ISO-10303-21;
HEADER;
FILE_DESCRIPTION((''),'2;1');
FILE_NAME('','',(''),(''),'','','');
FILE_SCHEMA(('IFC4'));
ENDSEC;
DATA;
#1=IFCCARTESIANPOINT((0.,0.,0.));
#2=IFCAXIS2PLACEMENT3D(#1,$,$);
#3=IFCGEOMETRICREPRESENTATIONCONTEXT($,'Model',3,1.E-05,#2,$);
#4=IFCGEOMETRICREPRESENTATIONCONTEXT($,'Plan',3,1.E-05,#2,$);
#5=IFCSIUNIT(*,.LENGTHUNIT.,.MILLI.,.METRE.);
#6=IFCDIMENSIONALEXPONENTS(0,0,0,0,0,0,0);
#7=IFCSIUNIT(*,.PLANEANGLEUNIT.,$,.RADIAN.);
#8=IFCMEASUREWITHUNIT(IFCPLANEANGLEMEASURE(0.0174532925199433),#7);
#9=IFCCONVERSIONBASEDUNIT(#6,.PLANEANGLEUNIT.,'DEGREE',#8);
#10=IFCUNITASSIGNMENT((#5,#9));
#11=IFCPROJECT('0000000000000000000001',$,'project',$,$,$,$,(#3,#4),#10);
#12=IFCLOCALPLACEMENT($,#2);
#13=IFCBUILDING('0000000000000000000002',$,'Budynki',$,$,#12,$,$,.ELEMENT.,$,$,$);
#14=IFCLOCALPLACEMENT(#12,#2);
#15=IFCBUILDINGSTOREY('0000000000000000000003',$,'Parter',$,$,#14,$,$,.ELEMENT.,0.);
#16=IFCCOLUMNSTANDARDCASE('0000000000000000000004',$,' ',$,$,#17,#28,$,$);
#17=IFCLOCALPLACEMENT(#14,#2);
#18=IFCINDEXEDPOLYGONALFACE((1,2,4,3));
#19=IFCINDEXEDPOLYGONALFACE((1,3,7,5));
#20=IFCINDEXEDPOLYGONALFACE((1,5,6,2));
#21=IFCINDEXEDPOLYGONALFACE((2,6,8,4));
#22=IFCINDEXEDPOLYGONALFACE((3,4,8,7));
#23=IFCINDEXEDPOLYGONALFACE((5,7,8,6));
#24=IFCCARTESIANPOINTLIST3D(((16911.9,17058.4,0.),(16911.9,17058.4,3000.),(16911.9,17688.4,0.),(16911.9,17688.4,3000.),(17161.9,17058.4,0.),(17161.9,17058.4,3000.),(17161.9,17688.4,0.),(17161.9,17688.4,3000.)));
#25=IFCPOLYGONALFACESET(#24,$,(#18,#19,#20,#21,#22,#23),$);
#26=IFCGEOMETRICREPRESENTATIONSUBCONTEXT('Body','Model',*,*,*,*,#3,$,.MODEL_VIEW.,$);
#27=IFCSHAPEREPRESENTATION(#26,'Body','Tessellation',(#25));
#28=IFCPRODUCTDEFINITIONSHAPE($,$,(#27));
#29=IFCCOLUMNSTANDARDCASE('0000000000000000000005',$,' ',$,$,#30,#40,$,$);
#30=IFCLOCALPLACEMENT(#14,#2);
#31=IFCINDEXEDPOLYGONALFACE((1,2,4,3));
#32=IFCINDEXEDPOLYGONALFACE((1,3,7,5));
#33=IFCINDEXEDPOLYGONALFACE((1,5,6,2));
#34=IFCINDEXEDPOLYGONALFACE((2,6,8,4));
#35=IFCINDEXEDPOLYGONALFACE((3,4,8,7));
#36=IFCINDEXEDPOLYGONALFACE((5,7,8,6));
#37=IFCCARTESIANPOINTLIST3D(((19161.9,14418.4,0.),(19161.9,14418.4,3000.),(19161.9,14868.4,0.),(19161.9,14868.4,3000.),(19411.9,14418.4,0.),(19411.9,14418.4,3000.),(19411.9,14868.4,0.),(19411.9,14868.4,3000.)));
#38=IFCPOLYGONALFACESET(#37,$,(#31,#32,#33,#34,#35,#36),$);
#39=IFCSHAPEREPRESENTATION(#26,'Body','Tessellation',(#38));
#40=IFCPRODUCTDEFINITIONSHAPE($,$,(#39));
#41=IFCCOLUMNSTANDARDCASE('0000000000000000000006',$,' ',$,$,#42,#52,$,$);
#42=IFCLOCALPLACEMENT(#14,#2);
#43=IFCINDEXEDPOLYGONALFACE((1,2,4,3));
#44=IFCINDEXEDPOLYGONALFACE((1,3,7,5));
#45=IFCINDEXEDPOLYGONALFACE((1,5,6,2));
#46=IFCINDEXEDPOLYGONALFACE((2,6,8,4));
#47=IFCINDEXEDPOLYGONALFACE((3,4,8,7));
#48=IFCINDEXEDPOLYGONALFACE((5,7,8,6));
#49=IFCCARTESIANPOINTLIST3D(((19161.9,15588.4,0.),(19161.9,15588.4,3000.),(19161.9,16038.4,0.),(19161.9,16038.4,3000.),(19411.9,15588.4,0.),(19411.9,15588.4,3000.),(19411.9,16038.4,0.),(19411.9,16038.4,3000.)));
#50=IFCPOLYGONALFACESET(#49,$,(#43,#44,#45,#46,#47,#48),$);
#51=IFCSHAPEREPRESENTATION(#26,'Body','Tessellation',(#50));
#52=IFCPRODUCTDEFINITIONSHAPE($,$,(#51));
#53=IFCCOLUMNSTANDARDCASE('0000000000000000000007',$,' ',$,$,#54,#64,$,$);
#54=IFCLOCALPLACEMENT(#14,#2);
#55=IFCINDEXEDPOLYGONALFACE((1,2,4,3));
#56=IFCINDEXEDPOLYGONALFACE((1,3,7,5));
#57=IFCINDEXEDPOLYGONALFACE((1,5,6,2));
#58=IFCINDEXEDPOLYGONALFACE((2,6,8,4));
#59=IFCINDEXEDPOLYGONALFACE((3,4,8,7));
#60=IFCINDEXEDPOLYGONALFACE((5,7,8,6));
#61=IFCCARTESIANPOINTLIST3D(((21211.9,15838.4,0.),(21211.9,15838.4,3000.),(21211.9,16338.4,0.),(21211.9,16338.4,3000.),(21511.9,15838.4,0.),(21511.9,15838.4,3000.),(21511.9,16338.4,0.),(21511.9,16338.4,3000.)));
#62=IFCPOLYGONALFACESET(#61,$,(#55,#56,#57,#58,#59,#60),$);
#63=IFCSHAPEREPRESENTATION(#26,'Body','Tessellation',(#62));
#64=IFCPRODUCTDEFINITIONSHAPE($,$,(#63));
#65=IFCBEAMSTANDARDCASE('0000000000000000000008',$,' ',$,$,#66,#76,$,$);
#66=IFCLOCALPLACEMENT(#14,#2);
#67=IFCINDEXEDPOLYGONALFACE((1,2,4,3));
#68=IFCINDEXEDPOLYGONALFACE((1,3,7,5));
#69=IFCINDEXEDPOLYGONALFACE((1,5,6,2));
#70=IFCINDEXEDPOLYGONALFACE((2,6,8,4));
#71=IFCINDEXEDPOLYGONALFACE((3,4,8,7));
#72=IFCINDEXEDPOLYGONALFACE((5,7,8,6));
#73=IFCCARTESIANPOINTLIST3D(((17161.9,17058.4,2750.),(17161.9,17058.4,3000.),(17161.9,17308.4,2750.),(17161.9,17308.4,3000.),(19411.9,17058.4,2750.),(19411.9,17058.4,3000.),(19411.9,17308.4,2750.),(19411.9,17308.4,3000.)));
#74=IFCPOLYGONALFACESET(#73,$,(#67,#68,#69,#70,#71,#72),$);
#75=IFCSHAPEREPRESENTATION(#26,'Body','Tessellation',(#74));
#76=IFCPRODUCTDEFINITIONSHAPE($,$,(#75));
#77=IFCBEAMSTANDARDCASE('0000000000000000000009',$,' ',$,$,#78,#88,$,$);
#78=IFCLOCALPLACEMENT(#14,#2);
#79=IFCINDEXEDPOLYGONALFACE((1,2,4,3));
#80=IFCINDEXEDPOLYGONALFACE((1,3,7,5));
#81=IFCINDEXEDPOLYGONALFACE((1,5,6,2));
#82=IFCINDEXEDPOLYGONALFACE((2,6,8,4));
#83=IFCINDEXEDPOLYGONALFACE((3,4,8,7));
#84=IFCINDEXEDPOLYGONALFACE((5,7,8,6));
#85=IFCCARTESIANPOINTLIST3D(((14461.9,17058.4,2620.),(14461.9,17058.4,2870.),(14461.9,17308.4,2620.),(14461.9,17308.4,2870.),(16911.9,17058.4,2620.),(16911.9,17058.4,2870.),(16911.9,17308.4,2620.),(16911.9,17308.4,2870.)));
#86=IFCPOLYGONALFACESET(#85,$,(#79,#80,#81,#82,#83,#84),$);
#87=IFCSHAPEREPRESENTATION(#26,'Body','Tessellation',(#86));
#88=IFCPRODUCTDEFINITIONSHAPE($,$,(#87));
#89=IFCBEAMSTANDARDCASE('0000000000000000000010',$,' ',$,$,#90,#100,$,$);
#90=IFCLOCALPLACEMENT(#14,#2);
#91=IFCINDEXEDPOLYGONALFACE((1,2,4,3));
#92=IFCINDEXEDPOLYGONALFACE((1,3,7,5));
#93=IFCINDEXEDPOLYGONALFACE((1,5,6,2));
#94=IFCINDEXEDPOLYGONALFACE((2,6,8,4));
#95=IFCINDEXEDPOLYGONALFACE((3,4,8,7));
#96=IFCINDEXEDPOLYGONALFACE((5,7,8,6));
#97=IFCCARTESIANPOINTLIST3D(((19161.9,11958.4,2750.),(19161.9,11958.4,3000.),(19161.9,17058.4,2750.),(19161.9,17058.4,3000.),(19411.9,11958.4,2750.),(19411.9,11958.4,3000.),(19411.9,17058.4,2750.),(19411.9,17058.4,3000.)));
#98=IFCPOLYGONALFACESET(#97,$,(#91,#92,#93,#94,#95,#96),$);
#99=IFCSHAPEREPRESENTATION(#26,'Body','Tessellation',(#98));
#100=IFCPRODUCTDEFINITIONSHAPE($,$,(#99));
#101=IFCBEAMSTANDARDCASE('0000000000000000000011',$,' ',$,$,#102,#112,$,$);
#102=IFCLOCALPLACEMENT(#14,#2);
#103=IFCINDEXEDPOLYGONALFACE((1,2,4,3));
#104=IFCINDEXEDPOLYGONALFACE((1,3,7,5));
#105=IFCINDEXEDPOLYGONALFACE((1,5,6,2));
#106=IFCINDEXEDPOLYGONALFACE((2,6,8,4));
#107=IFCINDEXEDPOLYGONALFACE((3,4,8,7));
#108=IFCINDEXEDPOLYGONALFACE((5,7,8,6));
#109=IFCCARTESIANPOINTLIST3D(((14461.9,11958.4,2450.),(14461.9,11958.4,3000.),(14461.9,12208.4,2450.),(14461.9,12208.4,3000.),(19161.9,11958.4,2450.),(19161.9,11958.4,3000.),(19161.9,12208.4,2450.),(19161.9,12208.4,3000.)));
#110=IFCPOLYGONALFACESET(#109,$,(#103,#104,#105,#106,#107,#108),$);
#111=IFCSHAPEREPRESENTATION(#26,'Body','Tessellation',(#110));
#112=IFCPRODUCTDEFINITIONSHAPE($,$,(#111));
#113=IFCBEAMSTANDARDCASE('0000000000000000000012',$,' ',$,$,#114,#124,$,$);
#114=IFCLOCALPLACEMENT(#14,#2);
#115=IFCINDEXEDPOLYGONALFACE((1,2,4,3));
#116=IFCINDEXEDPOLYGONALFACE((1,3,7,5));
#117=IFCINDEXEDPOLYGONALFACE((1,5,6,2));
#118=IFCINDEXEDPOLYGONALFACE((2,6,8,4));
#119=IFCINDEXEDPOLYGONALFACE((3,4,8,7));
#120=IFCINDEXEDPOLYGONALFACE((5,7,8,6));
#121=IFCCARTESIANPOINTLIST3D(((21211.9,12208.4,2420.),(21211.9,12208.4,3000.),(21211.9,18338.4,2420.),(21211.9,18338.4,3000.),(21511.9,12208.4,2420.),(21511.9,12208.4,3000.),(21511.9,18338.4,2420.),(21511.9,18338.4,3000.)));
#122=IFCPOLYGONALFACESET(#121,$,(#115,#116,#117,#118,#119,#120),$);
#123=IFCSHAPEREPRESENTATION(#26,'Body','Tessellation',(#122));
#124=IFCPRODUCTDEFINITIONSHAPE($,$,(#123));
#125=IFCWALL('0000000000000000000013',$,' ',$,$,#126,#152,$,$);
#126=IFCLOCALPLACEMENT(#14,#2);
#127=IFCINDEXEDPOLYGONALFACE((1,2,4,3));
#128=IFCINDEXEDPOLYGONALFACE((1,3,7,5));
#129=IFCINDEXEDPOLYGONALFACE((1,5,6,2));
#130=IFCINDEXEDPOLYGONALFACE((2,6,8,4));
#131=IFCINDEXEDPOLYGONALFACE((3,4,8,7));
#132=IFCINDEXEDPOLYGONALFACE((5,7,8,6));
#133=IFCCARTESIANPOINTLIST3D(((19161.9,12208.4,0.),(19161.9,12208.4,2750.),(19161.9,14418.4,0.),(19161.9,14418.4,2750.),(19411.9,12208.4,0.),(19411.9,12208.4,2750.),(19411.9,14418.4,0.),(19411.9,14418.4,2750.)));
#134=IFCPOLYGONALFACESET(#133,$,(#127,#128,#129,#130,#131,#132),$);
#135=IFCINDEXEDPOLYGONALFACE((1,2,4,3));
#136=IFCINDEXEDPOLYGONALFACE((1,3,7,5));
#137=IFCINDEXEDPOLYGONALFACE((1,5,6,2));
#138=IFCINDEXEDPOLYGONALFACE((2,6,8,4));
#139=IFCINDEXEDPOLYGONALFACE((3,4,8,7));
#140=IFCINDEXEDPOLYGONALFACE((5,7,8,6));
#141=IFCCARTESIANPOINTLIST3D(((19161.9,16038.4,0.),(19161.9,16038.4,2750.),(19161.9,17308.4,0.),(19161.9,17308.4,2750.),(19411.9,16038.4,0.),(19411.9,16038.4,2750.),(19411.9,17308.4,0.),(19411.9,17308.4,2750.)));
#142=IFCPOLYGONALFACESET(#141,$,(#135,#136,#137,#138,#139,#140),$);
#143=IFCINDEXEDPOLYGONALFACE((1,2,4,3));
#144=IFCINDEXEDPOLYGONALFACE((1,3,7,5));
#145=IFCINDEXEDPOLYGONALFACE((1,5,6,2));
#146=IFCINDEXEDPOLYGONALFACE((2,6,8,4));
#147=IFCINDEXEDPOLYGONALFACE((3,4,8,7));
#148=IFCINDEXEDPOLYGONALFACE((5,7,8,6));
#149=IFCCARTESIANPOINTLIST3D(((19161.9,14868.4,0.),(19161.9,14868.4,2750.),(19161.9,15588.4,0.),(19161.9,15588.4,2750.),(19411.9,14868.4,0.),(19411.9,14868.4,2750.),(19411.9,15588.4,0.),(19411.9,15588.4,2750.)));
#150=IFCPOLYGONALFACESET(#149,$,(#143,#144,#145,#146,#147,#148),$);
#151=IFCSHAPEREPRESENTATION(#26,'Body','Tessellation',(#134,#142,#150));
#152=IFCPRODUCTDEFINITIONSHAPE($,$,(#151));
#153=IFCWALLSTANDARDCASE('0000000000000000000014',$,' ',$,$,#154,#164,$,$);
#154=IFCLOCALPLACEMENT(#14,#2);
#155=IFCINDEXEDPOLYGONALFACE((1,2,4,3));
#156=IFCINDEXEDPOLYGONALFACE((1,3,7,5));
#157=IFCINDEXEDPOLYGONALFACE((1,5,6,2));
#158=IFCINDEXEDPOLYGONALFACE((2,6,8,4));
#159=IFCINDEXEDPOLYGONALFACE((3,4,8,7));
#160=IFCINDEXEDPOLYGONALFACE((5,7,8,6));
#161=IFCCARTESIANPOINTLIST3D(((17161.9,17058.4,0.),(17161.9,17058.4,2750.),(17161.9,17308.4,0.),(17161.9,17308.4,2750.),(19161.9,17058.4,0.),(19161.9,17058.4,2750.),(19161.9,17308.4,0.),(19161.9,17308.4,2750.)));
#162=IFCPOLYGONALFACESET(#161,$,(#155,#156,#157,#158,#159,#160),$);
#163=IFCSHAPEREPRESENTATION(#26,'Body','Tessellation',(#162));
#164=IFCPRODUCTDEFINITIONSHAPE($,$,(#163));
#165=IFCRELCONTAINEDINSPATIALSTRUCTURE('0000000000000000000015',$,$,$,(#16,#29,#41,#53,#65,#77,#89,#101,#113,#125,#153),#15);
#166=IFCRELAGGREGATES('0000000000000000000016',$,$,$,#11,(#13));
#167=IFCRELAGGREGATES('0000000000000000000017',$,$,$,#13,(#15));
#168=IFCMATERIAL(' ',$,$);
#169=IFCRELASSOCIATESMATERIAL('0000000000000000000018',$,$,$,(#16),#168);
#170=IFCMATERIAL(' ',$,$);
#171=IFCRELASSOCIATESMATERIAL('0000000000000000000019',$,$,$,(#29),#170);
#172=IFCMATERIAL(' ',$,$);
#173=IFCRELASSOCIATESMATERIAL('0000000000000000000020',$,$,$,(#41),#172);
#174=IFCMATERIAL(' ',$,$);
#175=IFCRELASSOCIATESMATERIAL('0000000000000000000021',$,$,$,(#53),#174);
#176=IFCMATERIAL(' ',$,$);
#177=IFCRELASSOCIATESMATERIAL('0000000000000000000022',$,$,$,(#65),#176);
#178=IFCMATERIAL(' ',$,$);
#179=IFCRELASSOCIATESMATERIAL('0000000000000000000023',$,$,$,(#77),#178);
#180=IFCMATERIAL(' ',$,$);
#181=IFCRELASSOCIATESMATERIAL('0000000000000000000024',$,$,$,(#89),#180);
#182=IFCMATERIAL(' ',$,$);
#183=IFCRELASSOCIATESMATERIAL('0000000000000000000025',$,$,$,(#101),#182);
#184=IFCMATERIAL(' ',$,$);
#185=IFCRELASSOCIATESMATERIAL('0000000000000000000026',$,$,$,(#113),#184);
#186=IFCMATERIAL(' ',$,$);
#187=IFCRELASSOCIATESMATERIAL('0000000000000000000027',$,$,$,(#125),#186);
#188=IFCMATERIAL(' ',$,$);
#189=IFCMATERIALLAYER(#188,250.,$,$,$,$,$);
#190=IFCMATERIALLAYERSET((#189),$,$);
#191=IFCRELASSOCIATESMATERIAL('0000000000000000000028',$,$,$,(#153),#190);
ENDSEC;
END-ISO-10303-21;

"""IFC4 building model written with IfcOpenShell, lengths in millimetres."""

from ifc_helpers import new_model, entity, si_unit, converted_unit, frame, frame_2d, origin, origin_with_axes, place, context, subcontext, project, spatial, rectangle, extrude, material, layer, layer_set, layer_usage, material_profile, profile_set, profile_usage, element, save


model = new_model("IFC4")

# Units and contexts
model_context = context("Model", 3, precision=1e-05, world=origin())
plan_context = context("Plan", 3, precision=1e-05, world=origin())
body_context = subcontext(model_context, "Body", "Model", "MODEL_VIEW")
ifc_project = project(units=[si_unit("LENGTHUNIT", "METRE", prefix="MILLI"), converted_unit("PLANEANGLEUNIT", "DEGREE", entity("IfcPlaneAngleMeasure", 0.0174532925199433), si_unit("PLANEANGLEUNIT", "RADIAN"), dimensions=[0, 0, 0, 0, 0, 0, 0])], contexts=[model_context, plan_context])

# Building, storey
building_placement = place(None, origin())
building = spatial("IfcBuilding", under=ifc_project, at=building_placement, Name="Budynki", CompositionType="ELEMENT")
storey_placement = place(building_placement, origin())
storey = spatial("IfcBuildingStorey", under=building, at=storey_placement, Name="Parter", CompositionType="ELEMENT", Elevation=0.0)

# Columns
ifc_material_1 = material(Name=" ")
ifc_material_profile_1 = material_profile(ifc_material_1, rectangle(XDim=630.0, YDim=250.0, at=frame_2d((-125.0, 315.0), x_axis=(0.0, 1.0))))
ifc_profile_set_1 = profile_set([ifc_material_profile_1])
ifc_profile_usage_1 = profile_usage(ifc_profile_set_1)
column_1_placement = place(storey_placement, frame((16911.9, 17058.4, 0.0)))
element("IfcColumnStandardCase", 1, at=column_1_placement, inside=storey, material=ifc_profile_usage_1, Name=" ", context=body_context, shape_type="SweptSolid", body=[
    extrude(rectangle(XDim=630.0, YDim=250.0, at=frame_2d((-125.0, 315.0), x_axis=(0.0, 1.0))), frame((250.0, 0.0, 0.0), z_axis=(0.0, 0.0, 1.0), x_axis=(1.0, 0.0, 0.0)), (0.0, 0.0, 1.0), 3000.0),
])
ifc_material_2 = material(Name=" ")
ifc_material_profile_2 = material_profile(ifc_material_2, rectangle(XDim=450.0, YDim=250.0, at=frame_2d((125.0, -225.0), x_axis=(0.0, -1.0))))
ifc_profile_set_2 = profile_set([ifc_material_profile_2])
ifc_profile_usage_2 = profile_usage(ifc_profile_set_2)
column_2_placement = place(storey_placement, frame((19161.9, 14418.4, 0.0)))
element("IfcColumnStandardCase", 2, at=column_2_placement, inside=storey, material=ifc_profile_usage_2, Name=" ", context=body_context, shape_type="SweptSolid", body=[
    extrude(rectangle(XDim=450.0, YDim=250.0, at=frame_2d((125.0, -225.0), x_axis=(0.0, -1.0))), frame((0.0, 450.0, 0.0), z_axis=(0.0, 0.0, 1.0), x_axis=(1.0, 0.0, 0.0)), (0.0, 0.0, 1.0), 3000.0),
])
ifc_material_3 = material(Name=" ")
ifc_material_profile_3 = material_profile(ifc_material_3, rectangle(XDim=450.0, YDim=250.0, at=frame_2d((-125.0, 225.0), x_axis=(0.0, 1.0))))
ifc_profile_set_3 = profile_set([ifc_material_profile_3])
ifc_profile_usage_3 = profile_usage(ifc_profile_set_3)
column_3_placement = place(storey_placement, frame((19161.9, 15588.4, 0.0)))
element("IfcColumnStandardCase", 3, at=column_3_placement, inside=storey, material=ifc_profile_usage_3, Name=" ", context=body_context, shape_type="SweptSolid", body=[
    extrude(rectangle(XDim=450.0, YDim=250.0, at=frame_2d((-125.0, 225.0), x_axis=(0.0, 1.0))), frame((250.0, 0.0, 0.0), z_axis=(0.0, 0.0, 1.0), x_axis=(1.0, 0.0, 0.0)), (0.0, 0.0, 1.0), 3000.0),
])
ifc_material_4 = material(Name=" ")
ifc_material_profile_4 = material_profile(ifc_material_4, rectangle(XDim=500.0, YDim=300.0, at=frame_2d((150.0, -250.0), x_axis=(0.0, -1.0))))
ifc_profile_set_4 = profile_set([ifc_material_profile_4])
ifc_profile_usage_4 = profile_usage(ifc_profile_set_4)
column_4_placement = place(storey_placement, frame((21211.9, 15838.4, 0.0)))
element("IfcColumnStandardCase", 4, at=column_4_placement, inside=storey, material=ifc_profile_usage_4, Name=" ", context=body_context, shape_type="SweptSolid", body=[
    extrude(rectangle(XDim=500.0, YDim=300.0, at=frame_2d((150.0, -250.0), x_axis=(0.0, -1.0))), frame((0.0, 500.0, 0.0), z_axis=(0.0, 0.0, 1.0), x_axis=(1.0, 0.0, 0.0)), (0.0, 0.0, 1.0), 3000.0),
])

# Beams
ifc_material_5 = material(Name=" ")
ifc_material_profile_5 = material_profile(ifc_material_5, rectangle(XDim=250.0, YDim=250.0, at=frame_2d((125.0, -125.0), x_axis=(0.0, 1.0))))
ifc_profile_set_5 = profile_set([ifc_material_profile_5])
ifc_profile_usage_5 = profile_usage(ifc_profile_set_5)
beam_1_placement = place(storey_placement, frame((17161.9, 17058.4, 2750.0), z_axis=(0.0, 0.0, 1.0), x_axis=(1.0, 0.0, 0.0)))
element("IfcBeamStandardCase", 5, at=beam_1_placement, inside=storey, material=ifc_profile_usage_5, Name=" ", context=body_context, shape_type="SweptSolid", body=[
    extrude(rectangle(XDim=250.0, YDim=250.0, at=frame_2d((125.0, -125.0), x_axis=(0.0, 1.0))), frame((0.0, 0.0, 0.0), z_axis=(1.0, 0.0, 0.0), x_axis=(0.0, 0.0, 1.0)), (0.0, 0.0, 1.0), 2250.0),
])
ifc_material_6 = material(Name=" ")
ifc_material_profile_6 = material_profile(ifc_material_6, rectangle(XDim=250.0, YDim=250.0, at=frame_2d((125.0, -125.0), x_axis=(0.0, 1.0))))
ifc_profile_set_6 = profile_set([ifc_material_profile_6])
ifc_profile_usage_6 = profile_usage(ifc_profile_set_6)
beam_2_placement = place(storey_placement, frame((16911.9, 17308.4, 2620.0), z_axis=(0.0, 0.0, 1.0), x_axis=(-1.0, 0.0, 0.0)))
element("IfcBeamStandardCase", 6, at=beam_2_placement, inside=storey, material=ifc_profile_usage_6, Name=" ", context=body_context, shape_type="SweptSolid", body=[
    extrude(rectangle(XDim=250.0, YDim=250.0, at=frame_2d((125.0, -125.0), x_axis=(0.0, 1.0))), frame((0.0, 0.0, 0.0), z_axis=(1.0, 0.0, 0.0), x_axis=(0.0, 0.0, 1.0)), (0.0, 0.0, 1.0), 2450.0),
])
ifc_material_7 = material(Name=" ")
ifc_material_profile_7 = material_profile(ifc_material_7, rectangle(XDim=250.0, YDim=250.0, at=frame_2d((125.0, -125.0), x_axis=(0.0, 1.0))))
ifc_profile_set_7 = profile_set([ifc_material_profile_7])
ifc_profile_usage_7 = profile_usage(ifc_profile_set_7)
beam_3_placement = place(storey_placement, frame((19161.9, 17058.4, 2750.0), z_axis=(0.0, 0.0, 1.0), x_axis=(0.0, -1.0, 0.0)))
element("IfcBeamStandardCase", 7, at=beam_3_placement, inside=storey, material=ifc_profile_usage_7, Name=" ", context=body_context, shape_type="SweptSolid", body=[
    extrude(rectangle(XDim=250.0, YDim=250.0, at=frame_2d((125.0, -125.0), x_axis=(0.0, 1.0))), frame((0.0, 0.0, 0.0), z_axis=(1.0, 0.0, 0.0), x_axis=(0.0, 0.0, 1.0)), (0.0, 0.0, 1.0), 5100.0),
])
ifc_material_8 = material(Name=" ")
ifc_material_profile_8 = material_profile(ifc_material_8, rectangle(XDim=250.0, YDim=550.0, at=frame_2d((275.0, -125.0), x_axis=(0.0, 1.0))))
ifc_profile_set_8 = profile_set([ifc_material_profile_8])
ifc_profile_usage_8 = profile_usage(ifc_profile_set_8)
beam_4_placement = place(storey_placement, frame((19161.9, 12208.4, 2450.0), z_axis=(0.0, 0.0, 1.0), x_axis=(-1.0, 0.0, 0.0)))
element("IfcBeamStandardCase", 8, at=beam_4_placement, inside=storey, material=ifc_profile_usage_8, Name=" ", context=body_context, shape_type="SweptSolid", body=[
    extrude(rectangle(XDim=250.0, YDim=550.0, at=frame_2d((275.0, -125.0), x_axis=(0.0, 1.0))), frame((0.0, 0.0, 0.0), z_axis=(1.0, 0.0, 0.0), x_axis=(0.0, 0.0, 1.0)), (0.0, 0.0, 1.0), 4700.0),
])
ifc_material_9 = material(Name=" ")
ifc_material_profile_9 = material_profile(ifc_material_9, rectangle(XDim=300.0, YDim=580.0, at=frame_2d((290.0, -150.0), x_axis=(0.0, 1.0))))
ifc_profile_set_9 = profile_set([ifc_material_profile_9])
ifc_profile_usage_9 = profile_usage(ifc_profile_set_9)
beam_5_placement = place(storey_placement, frame((21511.9, 12208.4, 2420.0), z_axis=(0.0, 0.0, 1.0), x_axis=(0.0, 1.0, 0.0)))
element("IfcBeamStandardCase", 9, at=beam_5_placement, inside=storey, material=ifc_profile_usage_9, Name=" ", context=body_context, shape_type="SweptSolid", body=[
    extrude(rectangle(XDim=300.0, YDim=580.0, at=frame_2d((290.0, -150.0), x_axis=(0.0, 1.0))), frame((0.0, 0.0, 0.0), z_axis=(1.0, 0.0, 0.0), x_axis=(0.0, 0.0, 1.0)), (0.0, 0.0, 1.0), 6130.0),
])

# Walls
ifc_material_10 = material(Name=" ")
wall_1_placement = place(storey_placement, frame((19411.9, 12208.4, 0.0), z_axis=(0.0, 0.0, 1.0), x_axis=(0.0, 1.0, 0.0)))
element("IfcWall", 10, at=wall_1_placement, inside=storey, material=ifc_material_10, Name=" ", context=body_context, shape_type="SweptSolid", body=[
    extrude(rectangle(XDim=2210.0, YDim=250.0, at=frame_2d((1105.0, 125.0), x_axis=(1.0, 0.0))), origin_with_axes(), (0.0, 0.0, 1.0), 2750.0),
    extrude(rectangle(XDim=1270.0, YDim=250.0, at=frame_2d((-635.0, -125.0), x_axis=(-1.0, 0.0))), frame((5100.0, 250.0, 0.0), z_axis=(0.0, 0.0, 1.0), x_axis=(1.0, 0.0, 0.0)), (0.0, 0.0, 1.0), 2750.0),
    extrude(rectangle(XDim=250.0, YDim=720.0, at=frame_2d((-360.0, 125.0), x_axis=(0.0, 1.0))), frame((3380.0, 0.0, 0.0), z_axis=(0.0, 0.0, 1.0), x_axis=(1.0, 0.0, 0.0)), (0.0, 0.0, 1.0), 2750.0),
])
ifc_material_11 = material(Name=" ")
ifc_layer_1 = layer(ifc_material_11, 250.0)
ifc_layer_set_1 = layer_set([ifc_layer_1])
ifc_layer_usage_1 = layer_usage(ifc_layer_set_1, "AXIS2", "POSITIVE", 0.0)
wall_2_placement = place(storey_placement, frame((19161.9, 17308.4, 0.0), z_axis=(0.0, 0.0, 1.0), x_axis=(-1.0, 0.0, 0.0)))
element("IfcWallStandardCase", 11, at=wall_2_placement, inside=storey, material=ifc_layer_usage_1, Name=" ", context=body_context, shape_type="SweptSolid", body=[
    extrude(rectangle(XDim=2000.0, YDim=250.0, at=frame_2d((1000.0, 125.0), x_axis=(1.0, 0.0))), origin_with_axes(), (0.0, 0.0, 1.0), 2750.0),
])

save(model, "model.ifc")
